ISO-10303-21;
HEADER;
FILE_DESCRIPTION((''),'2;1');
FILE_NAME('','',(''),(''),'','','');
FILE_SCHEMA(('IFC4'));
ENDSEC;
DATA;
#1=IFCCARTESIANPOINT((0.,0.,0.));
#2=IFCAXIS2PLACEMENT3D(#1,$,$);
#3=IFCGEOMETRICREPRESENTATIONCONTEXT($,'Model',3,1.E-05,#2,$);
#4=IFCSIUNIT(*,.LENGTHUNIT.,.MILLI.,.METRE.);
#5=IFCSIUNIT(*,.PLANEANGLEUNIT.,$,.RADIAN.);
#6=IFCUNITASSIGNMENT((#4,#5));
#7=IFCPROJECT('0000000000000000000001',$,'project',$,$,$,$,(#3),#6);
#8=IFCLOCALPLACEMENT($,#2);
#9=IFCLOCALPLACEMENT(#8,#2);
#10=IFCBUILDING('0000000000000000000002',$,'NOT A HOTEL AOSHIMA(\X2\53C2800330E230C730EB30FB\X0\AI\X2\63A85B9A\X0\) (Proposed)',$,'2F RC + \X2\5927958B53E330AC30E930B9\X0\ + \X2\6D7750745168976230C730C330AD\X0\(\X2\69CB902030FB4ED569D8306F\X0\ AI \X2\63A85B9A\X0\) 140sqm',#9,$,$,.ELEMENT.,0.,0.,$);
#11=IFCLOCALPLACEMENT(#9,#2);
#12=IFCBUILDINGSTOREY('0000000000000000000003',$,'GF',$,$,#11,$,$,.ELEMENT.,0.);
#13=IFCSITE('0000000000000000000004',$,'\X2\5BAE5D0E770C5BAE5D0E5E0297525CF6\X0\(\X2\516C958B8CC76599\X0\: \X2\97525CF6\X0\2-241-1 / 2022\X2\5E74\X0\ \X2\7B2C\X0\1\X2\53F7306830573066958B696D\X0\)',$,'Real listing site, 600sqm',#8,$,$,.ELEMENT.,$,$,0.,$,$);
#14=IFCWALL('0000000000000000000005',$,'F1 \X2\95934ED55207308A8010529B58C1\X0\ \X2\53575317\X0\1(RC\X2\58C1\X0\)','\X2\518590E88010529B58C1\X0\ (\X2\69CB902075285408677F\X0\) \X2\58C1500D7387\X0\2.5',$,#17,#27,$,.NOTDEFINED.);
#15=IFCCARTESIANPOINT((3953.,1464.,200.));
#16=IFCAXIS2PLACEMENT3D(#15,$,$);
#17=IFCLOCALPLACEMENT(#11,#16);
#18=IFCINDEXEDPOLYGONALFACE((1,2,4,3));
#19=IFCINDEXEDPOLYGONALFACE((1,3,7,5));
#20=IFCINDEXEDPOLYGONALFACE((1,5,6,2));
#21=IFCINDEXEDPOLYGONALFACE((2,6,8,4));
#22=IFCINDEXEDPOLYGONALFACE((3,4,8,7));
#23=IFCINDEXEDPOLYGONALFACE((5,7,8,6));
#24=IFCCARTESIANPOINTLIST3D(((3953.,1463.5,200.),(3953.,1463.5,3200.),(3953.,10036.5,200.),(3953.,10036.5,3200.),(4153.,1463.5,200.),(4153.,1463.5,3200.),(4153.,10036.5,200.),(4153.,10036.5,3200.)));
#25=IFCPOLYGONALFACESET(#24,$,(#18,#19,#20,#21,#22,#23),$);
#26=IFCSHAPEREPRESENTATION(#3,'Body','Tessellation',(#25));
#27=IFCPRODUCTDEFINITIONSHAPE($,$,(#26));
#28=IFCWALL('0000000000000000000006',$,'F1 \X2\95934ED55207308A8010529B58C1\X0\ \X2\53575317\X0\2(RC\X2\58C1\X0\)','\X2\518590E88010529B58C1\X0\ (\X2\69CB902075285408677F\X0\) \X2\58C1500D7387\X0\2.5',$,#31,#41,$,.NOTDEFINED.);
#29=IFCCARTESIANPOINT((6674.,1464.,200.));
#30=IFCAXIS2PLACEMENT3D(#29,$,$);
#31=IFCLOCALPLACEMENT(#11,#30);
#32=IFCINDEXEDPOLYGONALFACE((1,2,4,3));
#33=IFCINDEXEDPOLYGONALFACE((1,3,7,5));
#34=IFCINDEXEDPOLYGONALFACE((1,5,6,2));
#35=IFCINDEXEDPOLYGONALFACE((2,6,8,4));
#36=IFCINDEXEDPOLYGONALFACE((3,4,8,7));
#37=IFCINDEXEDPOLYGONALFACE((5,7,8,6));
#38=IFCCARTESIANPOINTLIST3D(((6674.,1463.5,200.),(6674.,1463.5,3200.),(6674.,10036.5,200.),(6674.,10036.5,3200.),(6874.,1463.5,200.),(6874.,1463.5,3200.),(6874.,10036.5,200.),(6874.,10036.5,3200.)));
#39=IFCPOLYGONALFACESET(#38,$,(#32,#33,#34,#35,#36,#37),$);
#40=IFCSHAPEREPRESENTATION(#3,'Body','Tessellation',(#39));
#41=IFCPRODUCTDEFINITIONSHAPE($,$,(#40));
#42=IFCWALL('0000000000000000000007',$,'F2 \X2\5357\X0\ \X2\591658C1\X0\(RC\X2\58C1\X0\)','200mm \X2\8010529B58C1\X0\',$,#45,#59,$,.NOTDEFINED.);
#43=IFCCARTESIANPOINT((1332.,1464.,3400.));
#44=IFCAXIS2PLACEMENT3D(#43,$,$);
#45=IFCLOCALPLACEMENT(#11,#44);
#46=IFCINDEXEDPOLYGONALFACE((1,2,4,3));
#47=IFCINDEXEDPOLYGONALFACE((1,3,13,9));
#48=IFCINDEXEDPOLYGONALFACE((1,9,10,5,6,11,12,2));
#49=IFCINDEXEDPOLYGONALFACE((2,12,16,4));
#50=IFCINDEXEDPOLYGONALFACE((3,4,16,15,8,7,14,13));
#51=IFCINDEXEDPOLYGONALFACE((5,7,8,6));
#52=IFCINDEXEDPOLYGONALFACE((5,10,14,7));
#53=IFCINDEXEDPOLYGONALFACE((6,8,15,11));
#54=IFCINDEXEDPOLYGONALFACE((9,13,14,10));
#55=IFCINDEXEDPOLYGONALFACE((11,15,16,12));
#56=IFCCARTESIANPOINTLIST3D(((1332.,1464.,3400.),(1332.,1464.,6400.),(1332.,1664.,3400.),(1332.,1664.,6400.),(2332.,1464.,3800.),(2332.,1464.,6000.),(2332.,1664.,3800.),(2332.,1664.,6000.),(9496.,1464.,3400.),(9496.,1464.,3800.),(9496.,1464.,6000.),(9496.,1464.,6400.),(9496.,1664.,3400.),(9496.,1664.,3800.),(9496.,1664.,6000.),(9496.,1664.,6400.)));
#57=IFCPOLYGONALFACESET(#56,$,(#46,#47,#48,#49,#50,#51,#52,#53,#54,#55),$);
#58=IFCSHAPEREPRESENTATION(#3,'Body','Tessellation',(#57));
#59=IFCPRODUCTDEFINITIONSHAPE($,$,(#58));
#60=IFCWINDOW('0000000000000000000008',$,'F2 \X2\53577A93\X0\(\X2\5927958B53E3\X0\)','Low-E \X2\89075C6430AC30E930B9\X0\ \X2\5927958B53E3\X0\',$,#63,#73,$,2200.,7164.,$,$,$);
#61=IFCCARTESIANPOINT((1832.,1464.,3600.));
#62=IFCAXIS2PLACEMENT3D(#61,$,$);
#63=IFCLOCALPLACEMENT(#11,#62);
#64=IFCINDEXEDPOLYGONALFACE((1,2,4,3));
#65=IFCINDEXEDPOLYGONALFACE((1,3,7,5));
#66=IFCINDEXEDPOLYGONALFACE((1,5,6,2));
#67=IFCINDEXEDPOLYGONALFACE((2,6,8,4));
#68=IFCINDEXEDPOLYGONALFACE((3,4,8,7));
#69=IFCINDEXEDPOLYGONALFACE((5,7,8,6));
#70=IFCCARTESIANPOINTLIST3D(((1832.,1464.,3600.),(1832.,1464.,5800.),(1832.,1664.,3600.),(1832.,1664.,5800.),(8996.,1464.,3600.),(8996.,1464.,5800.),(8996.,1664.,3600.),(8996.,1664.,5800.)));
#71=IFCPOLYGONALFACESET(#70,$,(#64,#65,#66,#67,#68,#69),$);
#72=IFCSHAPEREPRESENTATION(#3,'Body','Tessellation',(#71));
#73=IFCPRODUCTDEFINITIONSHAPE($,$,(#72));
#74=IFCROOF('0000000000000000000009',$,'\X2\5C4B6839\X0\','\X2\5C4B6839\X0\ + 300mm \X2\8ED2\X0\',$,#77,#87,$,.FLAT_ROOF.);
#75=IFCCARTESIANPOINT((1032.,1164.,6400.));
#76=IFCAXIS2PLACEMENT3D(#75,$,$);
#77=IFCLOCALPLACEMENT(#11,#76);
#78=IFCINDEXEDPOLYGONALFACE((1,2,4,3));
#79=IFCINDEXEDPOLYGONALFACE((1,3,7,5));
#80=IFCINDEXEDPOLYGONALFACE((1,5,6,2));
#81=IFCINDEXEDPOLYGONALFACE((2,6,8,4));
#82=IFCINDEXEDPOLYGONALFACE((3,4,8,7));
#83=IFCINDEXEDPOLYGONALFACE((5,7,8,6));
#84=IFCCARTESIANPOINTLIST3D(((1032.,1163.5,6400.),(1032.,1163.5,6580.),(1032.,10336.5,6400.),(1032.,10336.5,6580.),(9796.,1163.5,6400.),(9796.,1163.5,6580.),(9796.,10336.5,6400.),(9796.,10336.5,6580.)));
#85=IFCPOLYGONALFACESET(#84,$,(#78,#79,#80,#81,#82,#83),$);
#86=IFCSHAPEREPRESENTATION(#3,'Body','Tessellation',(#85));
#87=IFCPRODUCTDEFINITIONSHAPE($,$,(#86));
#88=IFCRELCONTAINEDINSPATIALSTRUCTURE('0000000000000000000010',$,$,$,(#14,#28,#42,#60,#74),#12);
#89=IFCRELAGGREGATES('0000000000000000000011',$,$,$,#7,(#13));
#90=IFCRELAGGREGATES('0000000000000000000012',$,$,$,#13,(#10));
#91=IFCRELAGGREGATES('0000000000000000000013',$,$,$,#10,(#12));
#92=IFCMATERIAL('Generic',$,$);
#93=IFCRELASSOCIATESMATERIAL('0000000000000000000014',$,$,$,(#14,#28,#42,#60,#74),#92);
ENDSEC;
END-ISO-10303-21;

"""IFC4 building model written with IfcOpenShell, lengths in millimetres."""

from ifc_helpers import new_model, si_unit, frame, frame_2d, origin, place, context, project, spatial, rectangle, extrude, material, element, fill, save


model = new_model("IFC4")

# Units and contexts
model_context = context("Model", 3, precision=1e-05, world=origin())
ifc_project = project(units=[si_unit("LENGTHUNIT", "METRE", prefix="MILLI"), si_unit("PLANEANGLEUNIT", "RADIAN")], contexts=[model_context])

# Site, building, storey
site_placement = place(None, origin())
site = spatial("IfcSite", under=ifc_project, at=site_placement, Name="宮崎県宮崎市青島(公開資料: 青島2-241-1 / 2022年 第1号として開業)", ObjectType="Real listing site, 600sqm", CompositionType="ELEMENT", RefElevation=0.0)
building_placement = place(site_placement, origin())
building = spatial("IfcBuilding", under=site, at=building_placement, Name="NOT A HOTEL AOSHIMA(参考モデル・AI推定) (Proposed)", ObjectType="2F RC + 大開口ガラス + 海側全面デッキ(構造・仕様は AI 推定) 140sqm", CompositionType="ELEMENT", ElevationOfRefHeight=0.0, ElevationOfTerrain=0.0)
storey_placement = place(building_placement, origin())
storey = spatial("IfcBuildingStorey", under=building, at=storey_placement, Name="GF", CompositionType="ELEMENT", Elevation=0.0)

# Shared definitions
ifc_material_1 = material(Name="Generic")

# Walls
wall_1_placement = place(storey_placement, frame((3953.0, 1464.0, 200.0)))
element("IfcWall", 1, at=wall_1_placement, inside=storey, material=ifc_material_1, Name="F1 間仕切り耐力壁 南北1(RC壁)", Description="内部耐力壁 (構造用合板) 壁倍率2.5", PredefinedType="NOTDEFINED", context=model_context, shape_type="SweptSolid", body=[
    extrude(rectangle(XDim=200.0, YDim=8573.0, at=frame_2d((100.0, 4286.0))), frame((3953.0, 1464.0, 200.0)), (0.0, 0.0, 1.0), 3000.0),
])
wall_2_placement = place(storey_placement, frame((6674.0, 1464.0, 200.0)))
element("IfcWall", 2, at=wall_2_placement, inside=storey, material=ifc_material_1, Name="F1 間仕切り耐力壁 南北2(RC壁)", Description="内部耐力壁 (構造用合板) 壁倍率2.5", PredefinedType="NOTDEFINED", context=model_context, shape_type="SweptSolid", body=[
    extrude(rectangle(XDim=200.0, YDim=8573.0, at=frame_2d((100.0, 4286.0))), frame((6674.0, 1464.0, 200.0)), (0.0, 0.0, 1.0), 3000.0),
])

# Wall, opening, window
wall_3_placement = place(storey_placement, frame((1332.0, 1464.0, 3400.0)))
wall_3 = element("IfcWall", 3, at=wall_3_placement, inside=storey, material=ifc_material_1, Name="F2 南 外壁(RC壁)", Description="200mm 耐力壁", PredefinedType="NOTDEFINED", context=model_context, shape_type="SweptSolid", body=[
    extrude(rectangle(XDim=8164.0, YDim=200.0, at=frame_2d((4082.0, 100.0))), frame((1332.0, 1464.0, 3400.0)), (0.0, 0.0, 1.0), 3000.0),
])
opening_1_placement = place(storey_placement, frame((1832.0, 1464.0, 3600.0)))
opening_1 = element("IfcOpeningElement", 4, at=opening_1_placement, cuts=wall_3, PredefinedType="NOTDEFINED", context=model_context, shape_type="SweptSolid", body=[
    extrude(rectangle(XDim=7164.0, YDim=200.0, at=frame_2d((3582.0, 100.0))), frame((1832.0, 1464.0, 3600.0)), (0.0, 0.0, 1.0), 2200.0),
])
window_1_placement = place(storey_placement, frame((1832.0, 1464.0, 3600.0)))
window_1 = element("IfcWindow", 5, at=window_1_placement, inside=storey, material=ifc_material_1, Name="F2 南窓(大開口)", Description="Low-E 複層ガラス 大開口", OverallHeight=2200.0, OverallWidth=7164.0, context=model_context, shape_type="SweptSolid", body=[
    extrude(rectangle(XDim=7164.0, YDim=200.0, at=frame_2d((3582.0, 100.0))), frame((1832.0, 1464.0, 3600.0)), (0.0, 0.0, 1.0), 2200.0),
])
fill(opening_1, window_1)

# Roof
roof_placement = place(storey_placement, frame((1032.0, 1164.0, 6400.0)))
element("IfcRoof", 6, at=roof_placement, inside=storey, material=ifc_material_1, Name="屋根", Description="屋根 + 300mm 軒", PredefinedType="FLAT_ROOF", context=model_context, shape_type="SweptSolid", body=[
    extrude(rectangle(XDim=8764.0, YDim=9173.0, at=frame_2d((4382.0, 4586.0))), frame((1032.0, 1164.0, 6400.0)), (0.0, 0.0, 1.0), 180.0),
])

save(model, "model.ifc")
